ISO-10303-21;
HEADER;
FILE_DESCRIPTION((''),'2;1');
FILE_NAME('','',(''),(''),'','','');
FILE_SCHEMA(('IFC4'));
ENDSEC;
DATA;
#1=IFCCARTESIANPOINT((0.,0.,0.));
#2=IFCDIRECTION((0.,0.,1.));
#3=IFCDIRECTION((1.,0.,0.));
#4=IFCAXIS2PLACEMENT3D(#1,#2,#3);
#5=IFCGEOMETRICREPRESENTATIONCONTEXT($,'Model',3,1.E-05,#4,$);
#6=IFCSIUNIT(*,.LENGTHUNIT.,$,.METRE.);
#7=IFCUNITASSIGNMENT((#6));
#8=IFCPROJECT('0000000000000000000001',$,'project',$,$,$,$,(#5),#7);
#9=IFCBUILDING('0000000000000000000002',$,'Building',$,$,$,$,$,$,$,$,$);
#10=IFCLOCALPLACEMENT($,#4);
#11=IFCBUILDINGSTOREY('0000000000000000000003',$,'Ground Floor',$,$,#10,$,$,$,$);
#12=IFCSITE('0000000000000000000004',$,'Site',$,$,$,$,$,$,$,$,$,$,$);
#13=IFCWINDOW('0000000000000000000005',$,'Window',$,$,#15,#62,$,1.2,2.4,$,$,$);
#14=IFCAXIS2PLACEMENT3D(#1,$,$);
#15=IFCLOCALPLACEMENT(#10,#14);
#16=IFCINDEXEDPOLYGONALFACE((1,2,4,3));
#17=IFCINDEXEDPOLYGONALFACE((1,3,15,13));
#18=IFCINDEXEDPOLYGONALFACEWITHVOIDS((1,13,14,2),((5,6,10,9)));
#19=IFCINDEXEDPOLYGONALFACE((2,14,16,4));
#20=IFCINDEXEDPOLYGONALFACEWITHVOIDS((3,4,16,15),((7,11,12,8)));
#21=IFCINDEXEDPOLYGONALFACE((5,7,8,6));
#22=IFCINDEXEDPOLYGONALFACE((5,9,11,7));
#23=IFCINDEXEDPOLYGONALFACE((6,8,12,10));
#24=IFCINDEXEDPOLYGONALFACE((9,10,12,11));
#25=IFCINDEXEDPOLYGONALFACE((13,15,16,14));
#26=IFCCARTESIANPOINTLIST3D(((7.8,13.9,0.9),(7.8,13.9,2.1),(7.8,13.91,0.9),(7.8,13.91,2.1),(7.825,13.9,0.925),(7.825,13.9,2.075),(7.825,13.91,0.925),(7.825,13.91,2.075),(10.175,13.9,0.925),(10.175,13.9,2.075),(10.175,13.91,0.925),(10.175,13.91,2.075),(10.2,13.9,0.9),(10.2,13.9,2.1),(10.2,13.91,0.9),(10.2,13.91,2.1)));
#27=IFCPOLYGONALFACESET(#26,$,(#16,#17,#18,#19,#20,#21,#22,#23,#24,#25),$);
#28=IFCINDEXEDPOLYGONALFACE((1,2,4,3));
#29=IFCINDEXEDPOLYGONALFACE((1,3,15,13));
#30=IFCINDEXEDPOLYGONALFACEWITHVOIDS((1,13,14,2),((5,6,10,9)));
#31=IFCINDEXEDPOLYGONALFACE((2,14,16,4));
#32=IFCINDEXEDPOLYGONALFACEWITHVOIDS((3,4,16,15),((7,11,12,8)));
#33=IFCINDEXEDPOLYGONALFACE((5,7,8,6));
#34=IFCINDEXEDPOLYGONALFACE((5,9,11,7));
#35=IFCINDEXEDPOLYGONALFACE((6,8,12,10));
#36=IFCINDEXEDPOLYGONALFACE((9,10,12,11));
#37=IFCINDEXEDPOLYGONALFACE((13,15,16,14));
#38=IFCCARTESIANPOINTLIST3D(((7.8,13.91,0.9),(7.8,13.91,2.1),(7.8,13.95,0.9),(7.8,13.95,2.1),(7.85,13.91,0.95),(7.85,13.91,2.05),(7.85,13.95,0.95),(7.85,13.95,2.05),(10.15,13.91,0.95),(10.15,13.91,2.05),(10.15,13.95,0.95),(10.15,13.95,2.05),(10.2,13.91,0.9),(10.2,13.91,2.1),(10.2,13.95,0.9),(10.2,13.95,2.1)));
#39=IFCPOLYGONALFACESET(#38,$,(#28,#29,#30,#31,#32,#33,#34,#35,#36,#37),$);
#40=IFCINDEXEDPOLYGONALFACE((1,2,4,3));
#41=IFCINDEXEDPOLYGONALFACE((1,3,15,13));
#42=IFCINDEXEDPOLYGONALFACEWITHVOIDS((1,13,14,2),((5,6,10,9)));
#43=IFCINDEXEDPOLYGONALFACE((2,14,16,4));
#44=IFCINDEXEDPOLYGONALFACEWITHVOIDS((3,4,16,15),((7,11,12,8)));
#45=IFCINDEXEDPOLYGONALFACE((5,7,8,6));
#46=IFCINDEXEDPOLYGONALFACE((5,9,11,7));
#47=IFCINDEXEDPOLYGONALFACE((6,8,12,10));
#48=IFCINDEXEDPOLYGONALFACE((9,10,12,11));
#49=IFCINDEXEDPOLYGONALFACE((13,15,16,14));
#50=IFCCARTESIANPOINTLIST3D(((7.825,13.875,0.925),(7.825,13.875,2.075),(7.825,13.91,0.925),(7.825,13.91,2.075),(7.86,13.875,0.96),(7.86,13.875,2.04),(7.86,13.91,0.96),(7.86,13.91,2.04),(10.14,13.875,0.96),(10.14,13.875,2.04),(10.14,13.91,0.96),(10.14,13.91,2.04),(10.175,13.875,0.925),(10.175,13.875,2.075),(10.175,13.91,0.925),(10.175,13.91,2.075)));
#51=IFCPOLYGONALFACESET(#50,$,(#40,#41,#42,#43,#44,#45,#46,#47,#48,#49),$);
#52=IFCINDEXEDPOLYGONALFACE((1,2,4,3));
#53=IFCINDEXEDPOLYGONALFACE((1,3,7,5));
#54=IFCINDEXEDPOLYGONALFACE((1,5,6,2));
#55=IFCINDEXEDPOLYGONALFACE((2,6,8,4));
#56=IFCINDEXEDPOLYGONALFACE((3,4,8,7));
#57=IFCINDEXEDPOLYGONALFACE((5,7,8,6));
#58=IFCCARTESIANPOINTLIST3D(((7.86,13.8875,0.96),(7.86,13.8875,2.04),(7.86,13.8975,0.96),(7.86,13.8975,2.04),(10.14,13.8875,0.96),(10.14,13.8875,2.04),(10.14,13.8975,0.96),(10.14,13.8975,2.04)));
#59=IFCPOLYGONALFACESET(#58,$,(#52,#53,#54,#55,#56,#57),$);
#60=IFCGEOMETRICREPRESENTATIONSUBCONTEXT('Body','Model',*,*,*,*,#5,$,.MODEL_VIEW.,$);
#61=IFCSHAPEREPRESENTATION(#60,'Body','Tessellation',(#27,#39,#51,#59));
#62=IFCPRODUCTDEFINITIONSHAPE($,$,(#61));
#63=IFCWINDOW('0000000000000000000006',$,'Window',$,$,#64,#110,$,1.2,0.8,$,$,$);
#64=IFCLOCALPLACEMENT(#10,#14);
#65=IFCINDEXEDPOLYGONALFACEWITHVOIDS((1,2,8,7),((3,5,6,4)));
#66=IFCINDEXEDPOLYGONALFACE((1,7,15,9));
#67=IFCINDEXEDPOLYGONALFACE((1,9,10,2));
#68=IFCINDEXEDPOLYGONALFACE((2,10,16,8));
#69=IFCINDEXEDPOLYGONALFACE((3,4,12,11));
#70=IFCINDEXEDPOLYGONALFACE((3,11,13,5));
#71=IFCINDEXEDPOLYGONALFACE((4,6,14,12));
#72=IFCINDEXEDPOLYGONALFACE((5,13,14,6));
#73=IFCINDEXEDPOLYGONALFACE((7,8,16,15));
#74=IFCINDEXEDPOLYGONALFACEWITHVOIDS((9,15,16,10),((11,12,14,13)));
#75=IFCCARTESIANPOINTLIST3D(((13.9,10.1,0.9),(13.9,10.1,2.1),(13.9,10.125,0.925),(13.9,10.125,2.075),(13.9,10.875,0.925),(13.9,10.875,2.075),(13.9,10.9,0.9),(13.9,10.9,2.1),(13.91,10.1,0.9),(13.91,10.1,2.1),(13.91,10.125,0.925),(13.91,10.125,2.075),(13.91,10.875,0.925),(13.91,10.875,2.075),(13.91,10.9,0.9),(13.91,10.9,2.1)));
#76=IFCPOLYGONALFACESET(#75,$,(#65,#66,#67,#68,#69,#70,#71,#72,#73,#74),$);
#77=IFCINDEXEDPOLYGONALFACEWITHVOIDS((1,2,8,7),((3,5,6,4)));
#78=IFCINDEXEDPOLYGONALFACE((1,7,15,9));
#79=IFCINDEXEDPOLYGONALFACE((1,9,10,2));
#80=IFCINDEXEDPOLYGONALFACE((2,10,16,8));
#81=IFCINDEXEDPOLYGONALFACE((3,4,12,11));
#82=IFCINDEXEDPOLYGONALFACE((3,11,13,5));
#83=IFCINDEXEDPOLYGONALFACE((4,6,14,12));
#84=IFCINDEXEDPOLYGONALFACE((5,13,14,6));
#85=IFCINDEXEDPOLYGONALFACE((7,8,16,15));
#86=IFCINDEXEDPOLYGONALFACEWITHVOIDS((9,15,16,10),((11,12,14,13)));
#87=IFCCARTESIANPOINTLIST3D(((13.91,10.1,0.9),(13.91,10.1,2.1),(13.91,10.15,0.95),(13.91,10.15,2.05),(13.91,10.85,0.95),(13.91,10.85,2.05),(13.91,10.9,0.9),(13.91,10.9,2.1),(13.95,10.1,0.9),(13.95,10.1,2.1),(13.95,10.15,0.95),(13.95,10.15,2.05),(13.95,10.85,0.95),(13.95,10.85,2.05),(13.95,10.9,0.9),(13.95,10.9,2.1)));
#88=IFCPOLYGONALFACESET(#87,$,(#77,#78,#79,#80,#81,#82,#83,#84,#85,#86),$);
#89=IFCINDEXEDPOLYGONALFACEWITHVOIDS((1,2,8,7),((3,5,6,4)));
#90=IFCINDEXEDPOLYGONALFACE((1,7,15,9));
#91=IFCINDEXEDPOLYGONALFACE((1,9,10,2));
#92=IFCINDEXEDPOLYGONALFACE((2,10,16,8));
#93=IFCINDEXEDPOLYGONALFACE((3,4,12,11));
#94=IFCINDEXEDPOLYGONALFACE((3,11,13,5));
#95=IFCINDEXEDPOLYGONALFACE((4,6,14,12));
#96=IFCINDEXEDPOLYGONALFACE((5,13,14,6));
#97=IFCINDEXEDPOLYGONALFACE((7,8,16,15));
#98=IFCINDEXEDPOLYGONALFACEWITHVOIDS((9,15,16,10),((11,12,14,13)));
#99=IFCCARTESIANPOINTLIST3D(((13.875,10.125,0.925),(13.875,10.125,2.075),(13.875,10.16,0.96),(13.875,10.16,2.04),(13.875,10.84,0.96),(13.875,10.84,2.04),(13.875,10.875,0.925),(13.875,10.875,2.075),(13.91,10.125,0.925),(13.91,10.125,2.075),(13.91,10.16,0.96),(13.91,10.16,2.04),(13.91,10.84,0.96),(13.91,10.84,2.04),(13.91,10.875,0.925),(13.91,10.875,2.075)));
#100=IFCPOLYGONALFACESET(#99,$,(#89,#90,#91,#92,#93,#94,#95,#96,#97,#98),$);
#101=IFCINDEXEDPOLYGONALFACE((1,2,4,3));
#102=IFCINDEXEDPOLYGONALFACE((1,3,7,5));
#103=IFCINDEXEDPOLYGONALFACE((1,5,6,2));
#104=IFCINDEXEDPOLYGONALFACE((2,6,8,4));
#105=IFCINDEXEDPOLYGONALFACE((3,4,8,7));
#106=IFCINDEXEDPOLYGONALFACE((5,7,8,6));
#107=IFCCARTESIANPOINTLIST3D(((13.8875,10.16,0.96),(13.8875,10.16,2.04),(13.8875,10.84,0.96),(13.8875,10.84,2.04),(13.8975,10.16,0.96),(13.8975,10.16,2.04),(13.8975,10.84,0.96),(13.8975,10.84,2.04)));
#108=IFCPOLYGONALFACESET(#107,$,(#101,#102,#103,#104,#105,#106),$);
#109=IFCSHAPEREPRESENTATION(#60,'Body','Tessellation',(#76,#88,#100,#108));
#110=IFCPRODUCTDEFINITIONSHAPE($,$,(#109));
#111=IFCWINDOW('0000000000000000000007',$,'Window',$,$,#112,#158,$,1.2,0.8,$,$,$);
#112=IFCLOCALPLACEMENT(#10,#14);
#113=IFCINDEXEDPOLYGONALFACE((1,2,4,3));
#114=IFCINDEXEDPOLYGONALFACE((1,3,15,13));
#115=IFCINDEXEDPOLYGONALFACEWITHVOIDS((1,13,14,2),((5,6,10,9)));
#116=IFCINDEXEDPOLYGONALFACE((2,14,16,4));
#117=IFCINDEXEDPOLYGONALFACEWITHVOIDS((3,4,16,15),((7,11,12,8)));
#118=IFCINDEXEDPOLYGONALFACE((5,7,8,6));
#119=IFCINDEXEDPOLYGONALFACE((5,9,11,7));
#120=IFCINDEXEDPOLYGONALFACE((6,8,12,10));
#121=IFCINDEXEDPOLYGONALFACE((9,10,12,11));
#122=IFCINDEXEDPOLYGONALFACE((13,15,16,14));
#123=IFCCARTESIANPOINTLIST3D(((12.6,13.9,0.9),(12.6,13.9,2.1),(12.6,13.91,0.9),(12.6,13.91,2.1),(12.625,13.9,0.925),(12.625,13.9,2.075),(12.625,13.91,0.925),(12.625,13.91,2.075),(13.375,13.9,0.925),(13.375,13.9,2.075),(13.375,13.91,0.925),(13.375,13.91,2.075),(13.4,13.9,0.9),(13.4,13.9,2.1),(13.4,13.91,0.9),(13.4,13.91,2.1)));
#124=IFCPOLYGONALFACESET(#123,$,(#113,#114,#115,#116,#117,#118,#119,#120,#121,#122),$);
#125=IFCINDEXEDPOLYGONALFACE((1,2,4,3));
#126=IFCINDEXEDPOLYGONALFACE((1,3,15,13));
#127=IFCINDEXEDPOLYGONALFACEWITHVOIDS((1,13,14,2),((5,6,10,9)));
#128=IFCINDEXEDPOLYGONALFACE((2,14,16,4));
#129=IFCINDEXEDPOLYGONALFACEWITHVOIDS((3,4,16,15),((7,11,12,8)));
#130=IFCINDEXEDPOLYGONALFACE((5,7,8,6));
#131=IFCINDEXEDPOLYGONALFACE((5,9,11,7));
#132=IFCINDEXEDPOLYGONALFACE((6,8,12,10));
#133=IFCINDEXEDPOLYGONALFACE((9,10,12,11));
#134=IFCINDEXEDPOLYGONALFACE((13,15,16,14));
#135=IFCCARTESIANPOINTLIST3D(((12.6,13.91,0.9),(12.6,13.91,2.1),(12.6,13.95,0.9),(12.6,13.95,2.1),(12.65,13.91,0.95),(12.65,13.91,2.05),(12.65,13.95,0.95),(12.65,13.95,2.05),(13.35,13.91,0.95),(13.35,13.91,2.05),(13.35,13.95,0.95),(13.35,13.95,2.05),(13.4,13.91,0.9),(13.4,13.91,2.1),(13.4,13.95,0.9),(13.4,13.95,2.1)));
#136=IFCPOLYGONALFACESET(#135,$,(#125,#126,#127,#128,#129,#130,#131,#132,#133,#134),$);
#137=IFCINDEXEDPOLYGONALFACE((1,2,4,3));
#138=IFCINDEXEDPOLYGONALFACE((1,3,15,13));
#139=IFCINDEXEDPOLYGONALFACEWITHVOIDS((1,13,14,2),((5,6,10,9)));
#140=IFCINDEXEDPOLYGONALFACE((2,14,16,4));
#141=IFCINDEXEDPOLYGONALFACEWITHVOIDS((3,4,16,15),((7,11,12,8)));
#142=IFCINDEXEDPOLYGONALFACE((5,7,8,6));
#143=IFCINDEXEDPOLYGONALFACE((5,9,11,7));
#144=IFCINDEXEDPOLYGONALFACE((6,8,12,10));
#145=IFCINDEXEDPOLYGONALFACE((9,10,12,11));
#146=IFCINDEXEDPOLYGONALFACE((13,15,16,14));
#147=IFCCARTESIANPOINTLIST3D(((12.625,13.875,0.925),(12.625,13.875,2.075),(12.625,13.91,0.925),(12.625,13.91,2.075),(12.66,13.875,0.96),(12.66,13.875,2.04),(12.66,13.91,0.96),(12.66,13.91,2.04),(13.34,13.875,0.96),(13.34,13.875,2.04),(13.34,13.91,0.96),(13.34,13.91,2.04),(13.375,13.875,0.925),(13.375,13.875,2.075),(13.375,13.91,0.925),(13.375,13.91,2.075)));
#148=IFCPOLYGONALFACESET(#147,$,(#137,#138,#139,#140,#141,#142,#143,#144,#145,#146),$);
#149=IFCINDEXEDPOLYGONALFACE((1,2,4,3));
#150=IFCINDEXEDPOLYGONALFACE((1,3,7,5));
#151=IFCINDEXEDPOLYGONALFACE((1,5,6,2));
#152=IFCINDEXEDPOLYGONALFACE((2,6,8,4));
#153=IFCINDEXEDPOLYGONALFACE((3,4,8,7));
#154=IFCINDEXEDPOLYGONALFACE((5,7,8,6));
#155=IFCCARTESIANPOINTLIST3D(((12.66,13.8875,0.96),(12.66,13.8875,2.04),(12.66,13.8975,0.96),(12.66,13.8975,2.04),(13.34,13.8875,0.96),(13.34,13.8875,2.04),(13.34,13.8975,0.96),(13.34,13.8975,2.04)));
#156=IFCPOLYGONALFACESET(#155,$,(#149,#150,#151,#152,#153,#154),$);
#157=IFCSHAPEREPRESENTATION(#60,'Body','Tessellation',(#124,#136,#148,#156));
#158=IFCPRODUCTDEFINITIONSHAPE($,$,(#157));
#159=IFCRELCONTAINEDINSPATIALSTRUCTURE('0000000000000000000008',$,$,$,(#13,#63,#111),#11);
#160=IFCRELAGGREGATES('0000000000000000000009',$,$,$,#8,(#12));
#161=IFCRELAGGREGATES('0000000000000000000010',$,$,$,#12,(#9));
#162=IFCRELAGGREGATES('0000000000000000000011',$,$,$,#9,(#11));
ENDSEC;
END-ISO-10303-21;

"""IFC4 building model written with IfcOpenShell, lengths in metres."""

from ifc_helpers import new_model, si_unit, frame, origin_with_axes, place, context, subcontext, project, spatial, line, indexed_curve, outline, extrude, element, save


model = new_model("IFC4")

# Units and contexts
model_context = context("Model", 3, precision=1e-05, world=origin_with_axes())
body_context = subcontext(model_context, "Body", "Model", "MODEL_VIEW")
ifc_project = project(units=[si_unit("LENGTHUNIT", "METRE")], contexts=[model_context])

# Site, building, storey
site = spatial("IfcSite", under=ifc_project, Name="Site")
building = spatial("IfcBuilding", under=site, Name="Building")
storey_placement = place(None, origin_with_axes())
storey = spatial("IfcBuildingStorey", under=building, at=storey_placement, Name="Ground Floor")

# Windows
window_placement = place(storey_placement, frame((10.2, 14.0, 0.9), z_axis=(0.0, 0.0, 1.0), x_axis=(-1.0, 0.0, 0.0)))
element("IfcWindow", 1, at=window_placement, inside=storey, Name="Window", OverallHeight=1.2, OverallWidth=2.4, context=body_context, shape_type="SweptSolid", body=[
    extrude(outline(indexed_curve([(0.0, 0.0), (2.4, 0.0), (2.4, 1.2), (0.0, 1.2)], segments=[line(1, 2, 3, 4, 1)]), holes=[indexed_curve([(0.025, 0.025), (2.375, 0.025), (2.375, 1.175), (0.025, 1.175)], segments=[line(1, 2, 3, 4, 1)])]), frame((0.0, 0.09, 0.0), z_axis=(0.0, -1.0, 0.0), x_axis=(1.0, 0.0, 0.0)), (0.0, 0.0, -1.0), 0.01),
    extrude(outline(indexed_curve([(0.0, 0.0), (2.4, 0.0), (2.4, 1.2), (0.0, 1.2)], segments=[line(1, 2, 3, 4, 1)]), holes=[indexed_curve([(0.05, 0.05), (2.35, 0.05), (2.35, 1.15), (0.05, 1.15)], segments=[line(1, 2, 3, 4, 1)])]), frame((0.0, 0.05, 0.0), z_axis=(0.0, -1.0, 0.0), x_axis=(1.0, 0.0, 0.0)), (0.0, 0.0, -1.0), 0.04),
    extrude(outline(indexed_curve([(0.0, 0.0), (2.35, 0.0), (2.35, 1.15), (0.0, 1.15)], segments=[line(1, 2, 3, 4, 1)]), holes=[indexed_curve([(0.035, 0.035), (2.315, 0.035), (2.315, 1.115), (0.035, 1.115)], segments=[line(1, 2, 3, 4, 1)])]), frame((0.025, 0.09, 0.025), z_axis=(0.0, -1.0, 0.0), x_axis=(1.0, 0.0, 0.0)), (0.0, 0.0, -1.0), 0.035),
    extrude(outline(indexed_curve([(0.035, 0.035), (2.315, 0.035), (2.315, 1.115), (0.035, 1.115)], segments=[line(1, 2, 3, 4, 1)])), frame((0.025, 0.1025, 0.025), z_axis=(0.0, -1.0, 0.0), x_axis=(1.0, 0.0, 0.0)), (0.0, 0.0, -1.0), 0.01),
])
for number, where, z_axis, x_axis, name in (
    (2, (14.0, 10.1, 0.9), (0.0, 0.0, 1.0), (0.0, 1.0, 0.0), "Window"),
    (3, (13.4, 14.0, 0.9), (0.0, 0.0, 1.0), (-1.0, 0.0, 0.0), "Window"),
):
    element("IfcWindow", number, at=place(storey_placement, frame(where, z_axis=z_axis, x_axis=x_axis)), inside=storey, Name=name, OverallHeight=1.2, OverallWidth=0.8, context=body_context, shape_type="SweptSolid", body=[
        extrude(outline(indexed_curve([(0.0, 0.0), (0.8, 0.0), (0.8, 1.2), (0.0, 1.2)], segments=[line(1, 2, 3, 4, 1)]), holes=[indexed_curve([(0.025, 0.025), (0.775, 0.025), (0.775, 1.175), (0.025, 1.175)], segments=[line(1, 2, 3, 4, 1)])]), frame((0.0, 0.09, 0.0), z_axis=(0.0, -1.0, 0.0), x_axis=(1.0, 0.0, 0.0)), (0.0, 0.0, -1.0), 0.01),
        extrude(outline(indexed_curve([(0.0, 0.0), (0.8, 0.0), (0.8, 1.2), (0.0, 1.2)], segments=[line(1, 2, 3, 4, 1)]), holes=[indexed_curve([(0.05, 0.05), (0.75, 0.05), (0.75, 1.15), (0.05, 1.15)], segments=[line(1, 2, 3, 4, 1)])]), frame((0.0, 0.05, 0.0), z_axis=(0.0, -1.0, 0.0), x_axis=(1.0, 0.0, 0.0)), (0.0, 0.0, -1.0), 0.04),
        extrude(outline(indexed_curve([(0.0, 0.0), (0.75, 0.0), (0.75, 1.15), (0.0, 1.15)], segments=[line(1, 2, 3, 4, 1)]), holes=[indexed_curve([(0.035, 0.035), (0.715, 0.035), (0.715, 1.115), (0.035, 1.115)], segments=[line(1, 2, 3, 4, 1)])]), frame((0.025, 0.09, 0.025), z_axis=(0.0, -1.0, 0.0), x_axis=(1.0, 0.0, 0.0)), (0.0, 0.0, -1.0), 0.035),
        extrude(outline(indexed_curve([(0.035, 0.035), (0.715, 0.035), (0.715, 1.115), (0.035, 1.115)], segments=[line(1, 2, 3, 4, 1)])), frame((0.025, 0.1025, 0.025), z_axis=(0.0, -1.0, 0.0), x_axis=(1.0, 0.0, 0.0)), (0.0, 0.0, -1.0), 0.01),
    ])

save(model, "model.ifc")
